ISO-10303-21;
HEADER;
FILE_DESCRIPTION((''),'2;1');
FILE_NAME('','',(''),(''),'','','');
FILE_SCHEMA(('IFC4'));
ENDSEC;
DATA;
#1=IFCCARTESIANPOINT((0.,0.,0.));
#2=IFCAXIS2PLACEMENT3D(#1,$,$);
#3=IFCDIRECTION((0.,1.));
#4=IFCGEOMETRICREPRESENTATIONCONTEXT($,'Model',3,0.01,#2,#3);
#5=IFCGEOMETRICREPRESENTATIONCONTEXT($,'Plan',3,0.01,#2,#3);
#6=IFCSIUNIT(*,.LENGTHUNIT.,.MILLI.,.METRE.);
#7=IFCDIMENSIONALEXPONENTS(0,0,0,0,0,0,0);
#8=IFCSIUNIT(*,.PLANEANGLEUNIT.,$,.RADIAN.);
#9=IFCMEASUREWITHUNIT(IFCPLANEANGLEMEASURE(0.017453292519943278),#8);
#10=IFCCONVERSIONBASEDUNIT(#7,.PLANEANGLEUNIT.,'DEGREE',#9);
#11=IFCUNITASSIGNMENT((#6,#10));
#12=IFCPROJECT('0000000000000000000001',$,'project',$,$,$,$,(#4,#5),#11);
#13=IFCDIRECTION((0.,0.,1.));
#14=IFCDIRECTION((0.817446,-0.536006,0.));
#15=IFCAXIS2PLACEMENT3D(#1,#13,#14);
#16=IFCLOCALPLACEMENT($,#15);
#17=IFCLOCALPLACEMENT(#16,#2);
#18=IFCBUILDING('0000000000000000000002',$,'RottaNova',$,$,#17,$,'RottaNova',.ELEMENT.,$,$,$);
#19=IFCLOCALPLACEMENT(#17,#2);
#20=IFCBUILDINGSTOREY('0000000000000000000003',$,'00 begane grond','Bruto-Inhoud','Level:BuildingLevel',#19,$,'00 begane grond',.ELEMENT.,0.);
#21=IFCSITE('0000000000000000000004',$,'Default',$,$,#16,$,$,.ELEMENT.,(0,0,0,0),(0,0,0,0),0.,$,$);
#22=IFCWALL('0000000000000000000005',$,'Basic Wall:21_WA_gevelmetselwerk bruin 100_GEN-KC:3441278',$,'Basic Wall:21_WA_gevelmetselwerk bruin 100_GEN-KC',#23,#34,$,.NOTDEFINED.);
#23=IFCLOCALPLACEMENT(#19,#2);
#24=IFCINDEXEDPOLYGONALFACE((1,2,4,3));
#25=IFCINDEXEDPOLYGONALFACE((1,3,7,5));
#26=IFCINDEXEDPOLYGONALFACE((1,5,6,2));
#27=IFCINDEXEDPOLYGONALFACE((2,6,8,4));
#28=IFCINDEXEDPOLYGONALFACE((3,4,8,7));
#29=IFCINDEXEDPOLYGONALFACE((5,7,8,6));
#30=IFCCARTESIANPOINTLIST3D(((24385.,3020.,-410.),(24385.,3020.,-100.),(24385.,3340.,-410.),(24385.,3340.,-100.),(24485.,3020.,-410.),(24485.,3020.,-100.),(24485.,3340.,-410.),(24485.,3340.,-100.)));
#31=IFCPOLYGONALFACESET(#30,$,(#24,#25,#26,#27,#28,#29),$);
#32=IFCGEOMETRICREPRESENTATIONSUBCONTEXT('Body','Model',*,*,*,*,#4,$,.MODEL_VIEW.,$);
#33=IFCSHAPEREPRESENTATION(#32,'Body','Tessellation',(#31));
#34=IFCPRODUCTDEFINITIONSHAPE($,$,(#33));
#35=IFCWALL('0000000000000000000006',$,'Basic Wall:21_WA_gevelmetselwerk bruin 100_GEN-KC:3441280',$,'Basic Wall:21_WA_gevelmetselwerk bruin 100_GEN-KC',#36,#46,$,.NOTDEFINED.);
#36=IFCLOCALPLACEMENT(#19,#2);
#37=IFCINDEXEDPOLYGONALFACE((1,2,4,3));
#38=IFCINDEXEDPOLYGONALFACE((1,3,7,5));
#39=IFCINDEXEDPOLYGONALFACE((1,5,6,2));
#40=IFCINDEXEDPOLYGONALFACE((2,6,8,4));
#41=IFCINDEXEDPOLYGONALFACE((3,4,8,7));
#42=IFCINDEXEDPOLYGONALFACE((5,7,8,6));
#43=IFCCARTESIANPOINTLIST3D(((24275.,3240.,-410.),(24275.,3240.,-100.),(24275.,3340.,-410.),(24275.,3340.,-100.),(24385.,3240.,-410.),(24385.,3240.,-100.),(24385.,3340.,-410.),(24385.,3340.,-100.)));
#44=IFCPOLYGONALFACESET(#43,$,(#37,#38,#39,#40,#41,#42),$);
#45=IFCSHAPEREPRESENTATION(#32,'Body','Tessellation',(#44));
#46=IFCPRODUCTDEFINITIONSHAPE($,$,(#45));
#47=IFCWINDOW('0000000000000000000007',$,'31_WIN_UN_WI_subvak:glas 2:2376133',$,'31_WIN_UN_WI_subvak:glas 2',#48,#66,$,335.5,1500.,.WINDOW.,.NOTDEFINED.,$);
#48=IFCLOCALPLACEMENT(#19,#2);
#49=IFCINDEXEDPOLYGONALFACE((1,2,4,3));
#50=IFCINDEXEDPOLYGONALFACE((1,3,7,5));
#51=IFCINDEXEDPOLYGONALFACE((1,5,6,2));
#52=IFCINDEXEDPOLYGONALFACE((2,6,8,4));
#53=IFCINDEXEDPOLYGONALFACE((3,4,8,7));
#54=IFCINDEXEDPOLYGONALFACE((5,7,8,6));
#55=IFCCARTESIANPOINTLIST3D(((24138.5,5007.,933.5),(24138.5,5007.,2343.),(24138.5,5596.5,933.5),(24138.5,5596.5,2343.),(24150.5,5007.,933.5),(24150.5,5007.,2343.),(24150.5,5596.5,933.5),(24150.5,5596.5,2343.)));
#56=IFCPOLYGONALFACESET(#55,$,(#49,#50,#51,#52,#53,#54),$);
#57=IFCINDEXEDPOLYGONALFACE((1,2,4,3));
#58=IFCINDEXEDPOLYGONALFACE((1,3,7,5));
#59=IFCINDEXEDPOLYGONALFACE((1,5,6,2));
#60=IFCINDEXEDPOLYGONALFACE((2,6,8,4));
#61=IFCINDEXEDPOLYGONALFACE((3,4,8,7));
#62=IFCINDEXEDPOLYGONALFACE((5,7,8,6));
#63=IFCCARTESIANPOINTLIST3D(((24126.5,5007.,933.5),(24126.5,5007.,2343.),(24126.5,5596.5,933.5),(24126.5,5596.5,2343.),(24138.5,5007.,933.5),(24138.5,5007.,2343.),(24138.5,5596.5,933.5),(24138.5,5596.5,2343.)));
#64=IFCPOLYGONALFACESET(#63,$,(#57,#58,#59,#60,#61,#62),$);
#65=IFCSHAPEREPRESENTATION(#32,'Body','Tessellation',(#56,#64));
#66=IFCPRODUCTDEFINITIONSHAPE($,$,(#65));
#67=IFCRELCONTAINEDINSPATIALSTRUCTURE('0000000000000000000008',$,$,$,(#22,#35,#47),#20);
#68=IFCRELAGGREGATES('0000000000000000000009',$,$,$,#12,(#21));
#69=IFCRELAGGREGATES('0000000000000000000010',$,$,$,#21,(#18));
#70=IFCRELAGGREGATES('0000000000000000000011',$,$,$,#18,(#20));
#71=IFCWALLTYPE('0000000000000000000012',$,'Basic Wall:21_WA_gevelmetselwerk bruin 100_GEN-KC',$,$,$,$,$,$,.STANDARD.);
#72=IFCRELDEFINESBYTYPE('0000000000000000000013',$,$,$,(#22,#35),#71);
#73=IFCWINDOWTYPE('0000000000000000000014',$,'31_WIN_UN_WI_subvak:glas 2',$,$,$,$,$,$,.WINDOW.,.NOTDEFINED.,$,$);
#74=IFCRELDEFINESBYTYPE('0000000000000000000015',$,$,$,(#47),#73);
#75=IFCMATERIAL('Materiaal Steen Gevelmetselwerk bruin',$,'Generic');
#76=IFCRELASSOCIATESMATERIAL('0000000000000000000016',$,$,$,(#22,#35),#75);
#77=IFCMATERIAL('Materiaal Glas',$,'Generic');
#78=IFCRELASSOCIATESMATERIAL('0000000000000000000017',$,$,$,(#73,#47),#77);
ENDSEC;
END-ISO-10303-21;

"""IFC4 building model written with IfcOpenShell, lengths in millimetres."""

from ifc_helpers import new_model, entity, si_unit, converted_unit, direction, frame, origin, place, context, subcontext, project, spatial, indexed_curve, outline, extrude, source, transform, mapped, material, type_object, type_shapes, element, save


model = new_model("IFC4")

# Units and contexts
model_context = context("Model", 3, precision=0.01, world=origin(), true_north=direction((0.0, 1.0)))
plan_context = context("Plan", 3, precision=0.01, world=origin(), true_north=direction((0.0, 1.0)))
body_context = subcontext(model_context, "Body", "Model", "MODEL_VIEW")
ifc_project = project(units=[si_unit("LENGTHUNIT", "METRE", prefix="MILLI"), converted_unit("PLANEANGLEUNIT", "DEGREE", entity("IfcPlaneAngleMeasure", 0.017453292519943278), si_unit("PLANEANGLEUNIT", "RADIAN"), dimensions=[0, 0, 0, 0, 0, 0, 0])], contexts=[model_context, plan_context])

# Site, building, storey
site_placement = place(None, frame((0.0, 0.0, 0.0), z_axis=(0.0, 0.0, 1.0), x_axis=(0.817446, -0.536006, 0.0)))
site = spatial("IfcSite", under=ifc_project, at=site_placement, Name="Default", CompositionType="ELEMENT", RefLatitude=(0, 0, 0, 0), RefLongitude=(0, 0, 0, 0), RefElevation=0.0)
building_placement = place(site_placement, origin())
building = spatial("IfcBuilding", under=site, at=building_placement, Name="RottaNova", LongName="RottaNova", CompositionType="ELEMENT")
storey_placement = place(building_placement, origin())
storey = spatial("IfcBuildingStorey", under=building, at=storey_placement, Name="00 begane grond", Description="Bruto-Inhoud", ObjectType="Level:BuildingLevel", LongName="00 begane grond", CompositionType="ELEMENT", Elevation=0.0)

# Shared definitions
ifc_material_1 = material(Name="Materiaal Glas", Category="Generic")

# Walls
ifc_material_2 = material(Name="Materiaal Steen Gevelmetselwerk bruin", Category="Generic")
wall_type_1 = type_object("IfcWallType", Name="Basic Wall:21_WA_gevelmetselwerk bruin 100_GEN-KC", PredefinedType="STANDARD")
wall_1_placement = place(storey_placement, frame((24435.0, 3340.0, -410.0), z_axis=(0.0, 0.0, 1.0), x_axis=(0.0, -1.0, 0.0)))
element("IfcWall", 1, at=wall_1_placement, inside=storey, type_object=wall_type_1, material=ifc_material_2, Name="Basic Wall:21_WA_gevelmetselwerk bruin 100_GEN-KC:3441278", ObjectType="Basic Wall:21_WA_gevelmetselwerk bruin 100_GEN-KC", PredefinedType="NOTDEFINED", context=body_context, shape_type="SweptSolid", body=[
    extrude(outline(indexed_curve([(320.0, 50.0), (0.0, 50.0), (0.0, -50.0), (320.0, -50.0), (320.0, 50.0)], self_intersect=False)), origin(), (0.0, 0.0, 1.0), 310.0),
])
wall_2_placement = place(storey_placement, frame((24385.0, 3290.0, -410.0), z_axis=(0.0, 0.0, 1.0), x_axis=(-1.0, 0.0, 0.0)))
element("IfcWall", 2, at=wall_2_placement, inside=storey, type_object=wall_type_1, material=ifc_material_2, Name="Basic Wall:21_WA_gevelmetselwerk bruin 100_GEN-KC:3441280", ObjectType="Basic Wall:21_WA_gevelmetselwerk bruin 100_GEN-KC", PredefinedType="NOTDEFINED", context=body_context, shape_type="SweptSolid", body=[
    extrude(outline(indexed_curve([(110.0, 50.0), (0.0, 50.0), (0.0, -50.0), (110.0, -50.0), (110.0, 50.0)], self_intersect=False)), origin(), (0.0, 0.0, 1.0), 310.0),
])

# Window
window_type = type_object("IfcWindowType", Name="31_WIN_UN_WI_subvak:glas 2", PartitioningType="NOTDEFINED", PredefinedType="WINDOW", material=ifc_material_1)
shared_shape_1 = source(origin(), body_context, "Body", "SweptSolid", [
    extrude(outline(indexed_curve([(-6.0, -294.7), (6.0, -294.7), (6.0, 294.7), (-6.0, 294.7), (-6.0, -294.7)], self_intersect=False)), frame((0.0, 6.0, 0.0), z_axis=(0.0, 0.0, 1.0), x_axis=(0.0, -1.0, 0.0)), (0.0, 0.0, 1.0), 1409.5),
    extrude(outline(indexed_curve([(-6.0, -294.8), (6.0, -294.8), (6.0, 294.8), (-6.0, 294.8), (-6.0, -294.8)], self_intersect=False)), frame((0.0, -6.0, 0.0), z_axis=(0.0, 0.0, 1.0), x_axis=(0.0, -1.0, 0.0)), (0.0, 0.0, 1.0), 1409.5),
])
type_shapes(window_type, [shared_shape_1])
window_1_placement = place(storey_placement, frame((24138.5, 5301.7, 933.5), z_axis=(0.0, 0.0, 1.0), x_axis=(0.0, -1.0, 0.0)))
element("IfcWindow", 3, at=window_1_placement, inside=storey, type_object=window_type, material=ifc_material_1, Name="31_WIN_UN_WI_subvak:glas 2:2376133", ObjectType="31_WIN_UN_WI_subvak:glas 2", OverallHeight=335.5, OverallWidth=1500.0, PartitioningType="NOTDEFINED", PredefinedType="WINDOW", context=body_context, shape_type="MappedRepresentation", body=[
    mapped(shared_shape_1, transform((0.0, 0.0, 0.0), scale=1.0)),
])

save(model, "model.ifc")
